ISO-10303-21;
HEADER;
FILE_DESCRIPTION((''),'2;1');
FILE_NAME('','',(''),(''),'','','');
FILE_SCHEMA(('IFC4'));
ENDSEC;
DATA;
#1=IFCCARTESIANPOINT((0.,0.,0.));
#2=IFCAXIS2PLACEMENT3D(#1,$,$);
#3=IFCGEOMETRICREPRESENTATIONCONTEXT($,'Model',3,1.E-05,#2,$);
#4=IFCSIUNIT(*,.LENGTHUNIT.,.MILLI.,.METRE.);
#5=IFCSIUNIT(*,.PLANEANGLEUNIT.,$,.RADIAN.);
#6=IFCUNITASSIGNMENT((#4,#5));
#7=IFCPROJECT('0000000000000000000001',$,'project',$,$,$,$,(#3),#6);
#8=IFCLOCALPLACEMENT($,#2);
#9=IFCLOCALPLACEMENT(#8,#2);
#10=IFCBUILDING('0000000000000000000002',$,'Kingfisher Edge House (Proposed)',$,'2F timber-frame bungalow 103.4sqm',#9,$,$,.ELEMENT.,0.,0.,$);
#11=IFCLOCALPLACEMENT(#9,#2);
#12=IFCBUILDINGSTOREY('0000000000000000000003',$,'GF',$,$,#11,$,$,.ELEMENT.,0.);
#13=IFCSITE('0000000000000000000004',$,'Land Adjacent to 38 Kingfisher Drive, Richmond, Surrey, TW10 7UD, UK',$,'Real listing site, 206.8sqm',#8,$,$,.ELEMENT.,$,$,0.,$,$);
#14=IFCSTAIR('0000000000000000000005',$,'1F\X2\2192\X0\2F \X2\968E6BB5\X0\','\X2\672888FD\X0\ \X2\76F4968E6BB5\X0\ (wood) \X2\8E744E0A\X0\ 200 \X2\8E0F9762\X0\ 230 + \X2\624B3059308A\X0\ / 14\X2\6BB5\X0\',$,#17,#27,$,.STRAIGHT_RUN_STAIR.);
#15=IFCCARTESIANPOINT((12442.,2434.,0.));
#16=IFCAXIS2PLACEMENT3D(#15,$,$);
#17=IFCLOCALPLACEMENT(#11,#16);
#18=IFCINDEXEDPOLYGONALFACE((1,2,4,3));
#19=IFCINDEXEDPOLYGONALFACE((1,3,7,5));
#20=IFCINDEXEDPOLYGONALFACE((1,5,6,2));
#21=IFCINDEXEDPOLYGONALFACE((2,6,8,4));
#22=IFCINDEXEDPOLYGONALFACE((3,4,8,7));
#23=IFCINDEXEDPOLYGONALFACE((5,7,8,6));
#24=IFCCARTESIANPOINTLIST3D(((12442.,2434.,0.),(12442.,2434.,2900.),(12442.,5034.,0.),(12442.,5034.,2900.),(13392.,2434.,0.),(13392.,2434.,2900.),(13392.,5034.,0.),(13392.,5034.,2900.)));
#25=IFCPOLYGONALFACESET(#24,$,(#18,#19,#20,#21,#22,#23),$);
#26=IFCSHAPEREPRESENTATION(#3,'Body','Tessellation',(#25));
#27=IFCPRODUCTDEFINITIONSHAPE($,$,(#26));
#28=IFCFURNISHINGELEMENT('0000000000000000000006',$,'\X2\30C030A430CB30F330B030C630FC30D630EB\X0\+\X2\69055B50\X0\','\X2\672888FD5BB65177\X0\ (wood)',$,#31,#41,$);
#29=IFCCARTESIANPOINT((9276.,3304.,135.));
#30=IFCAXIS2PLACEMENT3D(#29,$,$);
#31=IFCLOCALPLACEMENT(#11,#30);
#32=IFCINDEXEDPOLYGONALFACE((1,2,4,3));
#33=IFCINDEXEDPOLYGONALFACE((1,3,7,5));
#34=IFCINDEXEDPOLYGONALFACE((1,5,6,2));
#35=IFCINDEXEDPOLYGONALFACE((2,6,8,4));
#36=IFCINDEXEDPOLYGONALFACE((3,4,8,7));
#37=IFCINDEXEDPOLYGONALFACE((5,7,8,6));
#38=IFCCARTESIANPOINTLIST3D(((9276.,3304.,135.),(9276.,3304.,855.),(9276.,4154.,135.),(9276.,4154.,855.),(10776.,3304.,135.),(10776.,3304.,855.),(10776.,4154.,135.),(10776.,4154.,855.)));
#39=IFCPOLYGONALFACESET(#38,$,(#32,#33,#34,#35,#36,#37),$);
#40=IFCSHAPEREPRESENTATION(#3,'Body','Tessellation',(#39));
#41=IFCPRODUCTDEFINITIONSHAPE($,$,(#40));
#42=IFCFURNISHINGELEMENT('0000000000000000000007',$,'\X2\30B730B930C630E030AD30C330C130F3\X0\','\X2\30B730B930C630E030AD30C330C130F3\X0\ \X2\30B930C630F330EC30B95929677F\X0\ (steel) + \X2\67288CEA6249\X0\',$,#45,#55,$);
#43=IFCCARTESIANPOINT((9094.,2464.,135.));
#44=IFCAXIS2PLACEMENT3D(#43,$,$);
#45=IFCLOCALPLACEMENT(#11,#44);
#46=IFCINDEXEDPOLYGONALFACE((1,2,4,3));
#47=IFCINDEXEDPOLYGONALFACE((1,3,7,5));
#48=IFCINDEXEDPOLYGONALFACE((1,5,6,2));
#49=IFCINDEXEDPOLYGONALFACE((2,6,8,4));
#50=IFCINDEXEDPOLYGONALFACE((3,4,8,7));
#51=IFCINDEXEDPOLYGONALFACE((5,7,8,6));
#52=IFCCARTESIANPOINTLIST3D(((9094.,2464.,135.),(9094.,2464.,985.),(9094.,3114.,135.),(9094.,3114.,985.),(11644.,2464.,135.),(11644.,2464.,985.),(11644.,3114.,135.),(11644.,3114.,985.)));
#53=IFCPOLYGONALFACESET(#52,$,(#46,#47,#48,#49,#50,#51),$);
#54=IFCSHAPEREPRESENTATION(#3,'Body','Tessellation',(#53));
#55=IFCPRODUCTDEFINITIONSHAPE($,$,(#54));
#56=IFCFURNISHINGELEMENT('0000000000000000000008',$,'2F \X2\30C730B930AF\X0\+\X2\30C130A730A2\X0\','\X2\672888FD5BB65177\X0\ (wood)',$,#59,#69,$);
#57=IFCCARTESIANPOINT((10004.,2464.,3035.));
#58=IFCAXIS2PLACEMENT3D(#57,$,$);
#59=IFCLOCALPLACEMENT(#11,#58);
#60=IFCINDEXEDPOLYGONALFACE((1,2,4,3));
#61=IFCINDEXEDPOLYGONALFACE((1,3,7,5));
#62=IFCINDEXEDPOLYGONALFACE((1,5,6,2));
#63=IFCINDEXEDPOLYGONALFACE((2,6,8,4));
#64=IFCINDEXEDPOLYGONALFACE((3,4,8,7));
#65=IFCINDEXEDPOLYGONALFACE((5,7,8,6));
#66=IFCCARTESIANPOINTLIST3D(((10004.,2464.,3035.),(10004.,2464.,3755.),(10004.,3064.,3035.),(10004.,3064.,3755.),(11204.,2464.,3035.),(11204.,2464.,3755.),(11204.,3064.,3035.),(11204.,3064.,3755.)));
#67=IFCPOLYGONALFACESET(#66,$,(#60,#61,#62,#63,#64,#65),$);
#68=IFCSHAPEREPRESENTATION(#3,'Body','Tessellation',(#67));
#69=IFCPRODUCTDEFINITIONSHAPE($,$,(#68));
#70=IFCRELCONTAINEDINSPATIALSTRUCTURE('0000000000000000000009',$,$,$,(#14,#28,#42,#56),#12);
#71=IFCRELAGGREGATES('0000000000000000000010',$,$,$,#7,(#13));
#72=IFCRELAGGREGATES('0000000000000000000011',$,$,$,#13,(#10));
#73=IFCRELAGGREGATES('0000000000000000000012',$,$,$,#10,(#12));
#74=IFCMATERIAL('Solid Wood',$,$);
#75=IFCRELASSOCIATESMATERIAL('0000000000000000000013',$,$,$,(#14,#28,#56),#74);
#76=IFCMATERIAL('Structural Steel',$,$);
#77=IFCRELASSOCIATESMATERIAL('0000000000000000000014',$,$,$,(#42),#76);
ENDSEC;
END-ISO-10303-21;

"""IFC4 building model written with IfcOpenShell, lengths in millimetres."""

from ifc_helpers import new_model, si_unit, frame, frame_2d, origin, place, context, project, spatial, rectangle, extrude, material, element, save


model = new_model("IFC4")

# Units and contexts
model_context = context("Model", 3, precision=1e-05, world=origin())
ifc_project = project(units=[si_unit("LENGTHUNIT", "METRE", prefix="MILLI"), si_unit("PLANEANGLEUNIT", "RADIAN")], contexts=[model_context])

# Site, building, storey
site_placement = place(None, origin())
site = spatial("IfcSite", under=ifc_project, at=site_placement, Name="Land Adjacent to 38 Kingfisher Drive, Richmond, Surrey, TW10 7UD, UK", ObjectType="Real listing site, 206.8sqm", CompositionType="ELEMENT", RefElevation=0.0)
building_placement = place(site_placement, origin())
building = spatial("IfcBuilding", under=site, at=building_placement, Name="Kingfisher Edge House (Proposed)", ObjectType="2F timber-frame bungalow 103.4sqm", CompositionType="ELEMENT", ElevationOfRefHeight=0.0, ElevationOfTerrain=0.0)
storey_placement = place(building_placement, origin())
storey = spatial("IfcBuildingStorey", under=building, at=storey_placement, Name="GF", CompositionType="ELEMENT", Elevation=0.0)

# Shared definitions
ifc_material_1 = material(Name="Solid Wood")

# Stair
stair_placement = place(storey_placement, frame((12442.0, 2434.0, 0.0)))
element("IfcStair", 1, at=stair_placement, inside=storey, material=ifc_material_1, Name="1F→2F 階段", Description="木製 直階段 (wood) 蹴上 200 踏面 230 + 手すり / 14段", PredefinedType="STRAIGHT_RUN_STAIR", context=model_context, shape_type="SweptSolid", body=[
    extrude(rectangle(XDim=950.0, YDim=2600.0, at=frame_2d((475.0, 1300.0))), frame((12442.0, 2434.0, 0.0)), (0.0, 0.0, 1.0), 2900.0),
])

# Furnishing elements
furnishing_1_placement = place(storey_placement, frame((9276.0, 3304.0, 135.0)))
element("IfcFurnishingElement", 2, at=furnishing_1_placement, inside=storey, material=ifc_material_1, Name="ダイニングテーブル+椅子", Description="木製家具 (wood)", context=model_context, shape_type="SweptSolid", body=[
    extrude(rectangle(XDim=1500.0, YDim=850.0, at=frame_2d((750.0, 425.0))), frame((9276.0, 3304.0, 135.0)), (0.0, 0.0, 1.0), 720.0),
])
ifc_material_2 = material(Name="Structural Steel")
furnishing_2_placement = place(storey_placement, frame((9094.0, 2464.0, 135.0)))
element("IfcFurnishingElement", 3, at=furnishing_2_placement, inside=storey, material=ifc_material_2, Name="システムキッチン", Description="システムキッチン ステンレス天板 (steel) + 木質扉", context=model_context, shape_type="SweptSolid", body=[
    extrude(rectangle(XDim=2550.0, YDim=650.0, at=frame_2d((1275.0, 325.0))), frame((9094.0, 2464.0, 135.0)), (0.0, 0.0, 1.0), 850.0),
])
furnishing_3_placement = place(storey_placement, frame((10004.0, 2464.0, 3035.0)))
element("IfcFurnishingElement", 4, at=furnishing_3_placement, inside=storey, material=ifc_material_1, Name="2F デスク+チェア", Description="木製家具 (wood)", context=model_context, shape_type="SweptSolid", body=[
    extrude(rectangle(XDim=1200.0, YDim=600.0, at=frame_2d((600.0, 300.0))), frame((10004.0, 2464.0, 3035.0)), (0.0, 0.0, 1.0), 720.0),
])

save(model, "model.ifc")
